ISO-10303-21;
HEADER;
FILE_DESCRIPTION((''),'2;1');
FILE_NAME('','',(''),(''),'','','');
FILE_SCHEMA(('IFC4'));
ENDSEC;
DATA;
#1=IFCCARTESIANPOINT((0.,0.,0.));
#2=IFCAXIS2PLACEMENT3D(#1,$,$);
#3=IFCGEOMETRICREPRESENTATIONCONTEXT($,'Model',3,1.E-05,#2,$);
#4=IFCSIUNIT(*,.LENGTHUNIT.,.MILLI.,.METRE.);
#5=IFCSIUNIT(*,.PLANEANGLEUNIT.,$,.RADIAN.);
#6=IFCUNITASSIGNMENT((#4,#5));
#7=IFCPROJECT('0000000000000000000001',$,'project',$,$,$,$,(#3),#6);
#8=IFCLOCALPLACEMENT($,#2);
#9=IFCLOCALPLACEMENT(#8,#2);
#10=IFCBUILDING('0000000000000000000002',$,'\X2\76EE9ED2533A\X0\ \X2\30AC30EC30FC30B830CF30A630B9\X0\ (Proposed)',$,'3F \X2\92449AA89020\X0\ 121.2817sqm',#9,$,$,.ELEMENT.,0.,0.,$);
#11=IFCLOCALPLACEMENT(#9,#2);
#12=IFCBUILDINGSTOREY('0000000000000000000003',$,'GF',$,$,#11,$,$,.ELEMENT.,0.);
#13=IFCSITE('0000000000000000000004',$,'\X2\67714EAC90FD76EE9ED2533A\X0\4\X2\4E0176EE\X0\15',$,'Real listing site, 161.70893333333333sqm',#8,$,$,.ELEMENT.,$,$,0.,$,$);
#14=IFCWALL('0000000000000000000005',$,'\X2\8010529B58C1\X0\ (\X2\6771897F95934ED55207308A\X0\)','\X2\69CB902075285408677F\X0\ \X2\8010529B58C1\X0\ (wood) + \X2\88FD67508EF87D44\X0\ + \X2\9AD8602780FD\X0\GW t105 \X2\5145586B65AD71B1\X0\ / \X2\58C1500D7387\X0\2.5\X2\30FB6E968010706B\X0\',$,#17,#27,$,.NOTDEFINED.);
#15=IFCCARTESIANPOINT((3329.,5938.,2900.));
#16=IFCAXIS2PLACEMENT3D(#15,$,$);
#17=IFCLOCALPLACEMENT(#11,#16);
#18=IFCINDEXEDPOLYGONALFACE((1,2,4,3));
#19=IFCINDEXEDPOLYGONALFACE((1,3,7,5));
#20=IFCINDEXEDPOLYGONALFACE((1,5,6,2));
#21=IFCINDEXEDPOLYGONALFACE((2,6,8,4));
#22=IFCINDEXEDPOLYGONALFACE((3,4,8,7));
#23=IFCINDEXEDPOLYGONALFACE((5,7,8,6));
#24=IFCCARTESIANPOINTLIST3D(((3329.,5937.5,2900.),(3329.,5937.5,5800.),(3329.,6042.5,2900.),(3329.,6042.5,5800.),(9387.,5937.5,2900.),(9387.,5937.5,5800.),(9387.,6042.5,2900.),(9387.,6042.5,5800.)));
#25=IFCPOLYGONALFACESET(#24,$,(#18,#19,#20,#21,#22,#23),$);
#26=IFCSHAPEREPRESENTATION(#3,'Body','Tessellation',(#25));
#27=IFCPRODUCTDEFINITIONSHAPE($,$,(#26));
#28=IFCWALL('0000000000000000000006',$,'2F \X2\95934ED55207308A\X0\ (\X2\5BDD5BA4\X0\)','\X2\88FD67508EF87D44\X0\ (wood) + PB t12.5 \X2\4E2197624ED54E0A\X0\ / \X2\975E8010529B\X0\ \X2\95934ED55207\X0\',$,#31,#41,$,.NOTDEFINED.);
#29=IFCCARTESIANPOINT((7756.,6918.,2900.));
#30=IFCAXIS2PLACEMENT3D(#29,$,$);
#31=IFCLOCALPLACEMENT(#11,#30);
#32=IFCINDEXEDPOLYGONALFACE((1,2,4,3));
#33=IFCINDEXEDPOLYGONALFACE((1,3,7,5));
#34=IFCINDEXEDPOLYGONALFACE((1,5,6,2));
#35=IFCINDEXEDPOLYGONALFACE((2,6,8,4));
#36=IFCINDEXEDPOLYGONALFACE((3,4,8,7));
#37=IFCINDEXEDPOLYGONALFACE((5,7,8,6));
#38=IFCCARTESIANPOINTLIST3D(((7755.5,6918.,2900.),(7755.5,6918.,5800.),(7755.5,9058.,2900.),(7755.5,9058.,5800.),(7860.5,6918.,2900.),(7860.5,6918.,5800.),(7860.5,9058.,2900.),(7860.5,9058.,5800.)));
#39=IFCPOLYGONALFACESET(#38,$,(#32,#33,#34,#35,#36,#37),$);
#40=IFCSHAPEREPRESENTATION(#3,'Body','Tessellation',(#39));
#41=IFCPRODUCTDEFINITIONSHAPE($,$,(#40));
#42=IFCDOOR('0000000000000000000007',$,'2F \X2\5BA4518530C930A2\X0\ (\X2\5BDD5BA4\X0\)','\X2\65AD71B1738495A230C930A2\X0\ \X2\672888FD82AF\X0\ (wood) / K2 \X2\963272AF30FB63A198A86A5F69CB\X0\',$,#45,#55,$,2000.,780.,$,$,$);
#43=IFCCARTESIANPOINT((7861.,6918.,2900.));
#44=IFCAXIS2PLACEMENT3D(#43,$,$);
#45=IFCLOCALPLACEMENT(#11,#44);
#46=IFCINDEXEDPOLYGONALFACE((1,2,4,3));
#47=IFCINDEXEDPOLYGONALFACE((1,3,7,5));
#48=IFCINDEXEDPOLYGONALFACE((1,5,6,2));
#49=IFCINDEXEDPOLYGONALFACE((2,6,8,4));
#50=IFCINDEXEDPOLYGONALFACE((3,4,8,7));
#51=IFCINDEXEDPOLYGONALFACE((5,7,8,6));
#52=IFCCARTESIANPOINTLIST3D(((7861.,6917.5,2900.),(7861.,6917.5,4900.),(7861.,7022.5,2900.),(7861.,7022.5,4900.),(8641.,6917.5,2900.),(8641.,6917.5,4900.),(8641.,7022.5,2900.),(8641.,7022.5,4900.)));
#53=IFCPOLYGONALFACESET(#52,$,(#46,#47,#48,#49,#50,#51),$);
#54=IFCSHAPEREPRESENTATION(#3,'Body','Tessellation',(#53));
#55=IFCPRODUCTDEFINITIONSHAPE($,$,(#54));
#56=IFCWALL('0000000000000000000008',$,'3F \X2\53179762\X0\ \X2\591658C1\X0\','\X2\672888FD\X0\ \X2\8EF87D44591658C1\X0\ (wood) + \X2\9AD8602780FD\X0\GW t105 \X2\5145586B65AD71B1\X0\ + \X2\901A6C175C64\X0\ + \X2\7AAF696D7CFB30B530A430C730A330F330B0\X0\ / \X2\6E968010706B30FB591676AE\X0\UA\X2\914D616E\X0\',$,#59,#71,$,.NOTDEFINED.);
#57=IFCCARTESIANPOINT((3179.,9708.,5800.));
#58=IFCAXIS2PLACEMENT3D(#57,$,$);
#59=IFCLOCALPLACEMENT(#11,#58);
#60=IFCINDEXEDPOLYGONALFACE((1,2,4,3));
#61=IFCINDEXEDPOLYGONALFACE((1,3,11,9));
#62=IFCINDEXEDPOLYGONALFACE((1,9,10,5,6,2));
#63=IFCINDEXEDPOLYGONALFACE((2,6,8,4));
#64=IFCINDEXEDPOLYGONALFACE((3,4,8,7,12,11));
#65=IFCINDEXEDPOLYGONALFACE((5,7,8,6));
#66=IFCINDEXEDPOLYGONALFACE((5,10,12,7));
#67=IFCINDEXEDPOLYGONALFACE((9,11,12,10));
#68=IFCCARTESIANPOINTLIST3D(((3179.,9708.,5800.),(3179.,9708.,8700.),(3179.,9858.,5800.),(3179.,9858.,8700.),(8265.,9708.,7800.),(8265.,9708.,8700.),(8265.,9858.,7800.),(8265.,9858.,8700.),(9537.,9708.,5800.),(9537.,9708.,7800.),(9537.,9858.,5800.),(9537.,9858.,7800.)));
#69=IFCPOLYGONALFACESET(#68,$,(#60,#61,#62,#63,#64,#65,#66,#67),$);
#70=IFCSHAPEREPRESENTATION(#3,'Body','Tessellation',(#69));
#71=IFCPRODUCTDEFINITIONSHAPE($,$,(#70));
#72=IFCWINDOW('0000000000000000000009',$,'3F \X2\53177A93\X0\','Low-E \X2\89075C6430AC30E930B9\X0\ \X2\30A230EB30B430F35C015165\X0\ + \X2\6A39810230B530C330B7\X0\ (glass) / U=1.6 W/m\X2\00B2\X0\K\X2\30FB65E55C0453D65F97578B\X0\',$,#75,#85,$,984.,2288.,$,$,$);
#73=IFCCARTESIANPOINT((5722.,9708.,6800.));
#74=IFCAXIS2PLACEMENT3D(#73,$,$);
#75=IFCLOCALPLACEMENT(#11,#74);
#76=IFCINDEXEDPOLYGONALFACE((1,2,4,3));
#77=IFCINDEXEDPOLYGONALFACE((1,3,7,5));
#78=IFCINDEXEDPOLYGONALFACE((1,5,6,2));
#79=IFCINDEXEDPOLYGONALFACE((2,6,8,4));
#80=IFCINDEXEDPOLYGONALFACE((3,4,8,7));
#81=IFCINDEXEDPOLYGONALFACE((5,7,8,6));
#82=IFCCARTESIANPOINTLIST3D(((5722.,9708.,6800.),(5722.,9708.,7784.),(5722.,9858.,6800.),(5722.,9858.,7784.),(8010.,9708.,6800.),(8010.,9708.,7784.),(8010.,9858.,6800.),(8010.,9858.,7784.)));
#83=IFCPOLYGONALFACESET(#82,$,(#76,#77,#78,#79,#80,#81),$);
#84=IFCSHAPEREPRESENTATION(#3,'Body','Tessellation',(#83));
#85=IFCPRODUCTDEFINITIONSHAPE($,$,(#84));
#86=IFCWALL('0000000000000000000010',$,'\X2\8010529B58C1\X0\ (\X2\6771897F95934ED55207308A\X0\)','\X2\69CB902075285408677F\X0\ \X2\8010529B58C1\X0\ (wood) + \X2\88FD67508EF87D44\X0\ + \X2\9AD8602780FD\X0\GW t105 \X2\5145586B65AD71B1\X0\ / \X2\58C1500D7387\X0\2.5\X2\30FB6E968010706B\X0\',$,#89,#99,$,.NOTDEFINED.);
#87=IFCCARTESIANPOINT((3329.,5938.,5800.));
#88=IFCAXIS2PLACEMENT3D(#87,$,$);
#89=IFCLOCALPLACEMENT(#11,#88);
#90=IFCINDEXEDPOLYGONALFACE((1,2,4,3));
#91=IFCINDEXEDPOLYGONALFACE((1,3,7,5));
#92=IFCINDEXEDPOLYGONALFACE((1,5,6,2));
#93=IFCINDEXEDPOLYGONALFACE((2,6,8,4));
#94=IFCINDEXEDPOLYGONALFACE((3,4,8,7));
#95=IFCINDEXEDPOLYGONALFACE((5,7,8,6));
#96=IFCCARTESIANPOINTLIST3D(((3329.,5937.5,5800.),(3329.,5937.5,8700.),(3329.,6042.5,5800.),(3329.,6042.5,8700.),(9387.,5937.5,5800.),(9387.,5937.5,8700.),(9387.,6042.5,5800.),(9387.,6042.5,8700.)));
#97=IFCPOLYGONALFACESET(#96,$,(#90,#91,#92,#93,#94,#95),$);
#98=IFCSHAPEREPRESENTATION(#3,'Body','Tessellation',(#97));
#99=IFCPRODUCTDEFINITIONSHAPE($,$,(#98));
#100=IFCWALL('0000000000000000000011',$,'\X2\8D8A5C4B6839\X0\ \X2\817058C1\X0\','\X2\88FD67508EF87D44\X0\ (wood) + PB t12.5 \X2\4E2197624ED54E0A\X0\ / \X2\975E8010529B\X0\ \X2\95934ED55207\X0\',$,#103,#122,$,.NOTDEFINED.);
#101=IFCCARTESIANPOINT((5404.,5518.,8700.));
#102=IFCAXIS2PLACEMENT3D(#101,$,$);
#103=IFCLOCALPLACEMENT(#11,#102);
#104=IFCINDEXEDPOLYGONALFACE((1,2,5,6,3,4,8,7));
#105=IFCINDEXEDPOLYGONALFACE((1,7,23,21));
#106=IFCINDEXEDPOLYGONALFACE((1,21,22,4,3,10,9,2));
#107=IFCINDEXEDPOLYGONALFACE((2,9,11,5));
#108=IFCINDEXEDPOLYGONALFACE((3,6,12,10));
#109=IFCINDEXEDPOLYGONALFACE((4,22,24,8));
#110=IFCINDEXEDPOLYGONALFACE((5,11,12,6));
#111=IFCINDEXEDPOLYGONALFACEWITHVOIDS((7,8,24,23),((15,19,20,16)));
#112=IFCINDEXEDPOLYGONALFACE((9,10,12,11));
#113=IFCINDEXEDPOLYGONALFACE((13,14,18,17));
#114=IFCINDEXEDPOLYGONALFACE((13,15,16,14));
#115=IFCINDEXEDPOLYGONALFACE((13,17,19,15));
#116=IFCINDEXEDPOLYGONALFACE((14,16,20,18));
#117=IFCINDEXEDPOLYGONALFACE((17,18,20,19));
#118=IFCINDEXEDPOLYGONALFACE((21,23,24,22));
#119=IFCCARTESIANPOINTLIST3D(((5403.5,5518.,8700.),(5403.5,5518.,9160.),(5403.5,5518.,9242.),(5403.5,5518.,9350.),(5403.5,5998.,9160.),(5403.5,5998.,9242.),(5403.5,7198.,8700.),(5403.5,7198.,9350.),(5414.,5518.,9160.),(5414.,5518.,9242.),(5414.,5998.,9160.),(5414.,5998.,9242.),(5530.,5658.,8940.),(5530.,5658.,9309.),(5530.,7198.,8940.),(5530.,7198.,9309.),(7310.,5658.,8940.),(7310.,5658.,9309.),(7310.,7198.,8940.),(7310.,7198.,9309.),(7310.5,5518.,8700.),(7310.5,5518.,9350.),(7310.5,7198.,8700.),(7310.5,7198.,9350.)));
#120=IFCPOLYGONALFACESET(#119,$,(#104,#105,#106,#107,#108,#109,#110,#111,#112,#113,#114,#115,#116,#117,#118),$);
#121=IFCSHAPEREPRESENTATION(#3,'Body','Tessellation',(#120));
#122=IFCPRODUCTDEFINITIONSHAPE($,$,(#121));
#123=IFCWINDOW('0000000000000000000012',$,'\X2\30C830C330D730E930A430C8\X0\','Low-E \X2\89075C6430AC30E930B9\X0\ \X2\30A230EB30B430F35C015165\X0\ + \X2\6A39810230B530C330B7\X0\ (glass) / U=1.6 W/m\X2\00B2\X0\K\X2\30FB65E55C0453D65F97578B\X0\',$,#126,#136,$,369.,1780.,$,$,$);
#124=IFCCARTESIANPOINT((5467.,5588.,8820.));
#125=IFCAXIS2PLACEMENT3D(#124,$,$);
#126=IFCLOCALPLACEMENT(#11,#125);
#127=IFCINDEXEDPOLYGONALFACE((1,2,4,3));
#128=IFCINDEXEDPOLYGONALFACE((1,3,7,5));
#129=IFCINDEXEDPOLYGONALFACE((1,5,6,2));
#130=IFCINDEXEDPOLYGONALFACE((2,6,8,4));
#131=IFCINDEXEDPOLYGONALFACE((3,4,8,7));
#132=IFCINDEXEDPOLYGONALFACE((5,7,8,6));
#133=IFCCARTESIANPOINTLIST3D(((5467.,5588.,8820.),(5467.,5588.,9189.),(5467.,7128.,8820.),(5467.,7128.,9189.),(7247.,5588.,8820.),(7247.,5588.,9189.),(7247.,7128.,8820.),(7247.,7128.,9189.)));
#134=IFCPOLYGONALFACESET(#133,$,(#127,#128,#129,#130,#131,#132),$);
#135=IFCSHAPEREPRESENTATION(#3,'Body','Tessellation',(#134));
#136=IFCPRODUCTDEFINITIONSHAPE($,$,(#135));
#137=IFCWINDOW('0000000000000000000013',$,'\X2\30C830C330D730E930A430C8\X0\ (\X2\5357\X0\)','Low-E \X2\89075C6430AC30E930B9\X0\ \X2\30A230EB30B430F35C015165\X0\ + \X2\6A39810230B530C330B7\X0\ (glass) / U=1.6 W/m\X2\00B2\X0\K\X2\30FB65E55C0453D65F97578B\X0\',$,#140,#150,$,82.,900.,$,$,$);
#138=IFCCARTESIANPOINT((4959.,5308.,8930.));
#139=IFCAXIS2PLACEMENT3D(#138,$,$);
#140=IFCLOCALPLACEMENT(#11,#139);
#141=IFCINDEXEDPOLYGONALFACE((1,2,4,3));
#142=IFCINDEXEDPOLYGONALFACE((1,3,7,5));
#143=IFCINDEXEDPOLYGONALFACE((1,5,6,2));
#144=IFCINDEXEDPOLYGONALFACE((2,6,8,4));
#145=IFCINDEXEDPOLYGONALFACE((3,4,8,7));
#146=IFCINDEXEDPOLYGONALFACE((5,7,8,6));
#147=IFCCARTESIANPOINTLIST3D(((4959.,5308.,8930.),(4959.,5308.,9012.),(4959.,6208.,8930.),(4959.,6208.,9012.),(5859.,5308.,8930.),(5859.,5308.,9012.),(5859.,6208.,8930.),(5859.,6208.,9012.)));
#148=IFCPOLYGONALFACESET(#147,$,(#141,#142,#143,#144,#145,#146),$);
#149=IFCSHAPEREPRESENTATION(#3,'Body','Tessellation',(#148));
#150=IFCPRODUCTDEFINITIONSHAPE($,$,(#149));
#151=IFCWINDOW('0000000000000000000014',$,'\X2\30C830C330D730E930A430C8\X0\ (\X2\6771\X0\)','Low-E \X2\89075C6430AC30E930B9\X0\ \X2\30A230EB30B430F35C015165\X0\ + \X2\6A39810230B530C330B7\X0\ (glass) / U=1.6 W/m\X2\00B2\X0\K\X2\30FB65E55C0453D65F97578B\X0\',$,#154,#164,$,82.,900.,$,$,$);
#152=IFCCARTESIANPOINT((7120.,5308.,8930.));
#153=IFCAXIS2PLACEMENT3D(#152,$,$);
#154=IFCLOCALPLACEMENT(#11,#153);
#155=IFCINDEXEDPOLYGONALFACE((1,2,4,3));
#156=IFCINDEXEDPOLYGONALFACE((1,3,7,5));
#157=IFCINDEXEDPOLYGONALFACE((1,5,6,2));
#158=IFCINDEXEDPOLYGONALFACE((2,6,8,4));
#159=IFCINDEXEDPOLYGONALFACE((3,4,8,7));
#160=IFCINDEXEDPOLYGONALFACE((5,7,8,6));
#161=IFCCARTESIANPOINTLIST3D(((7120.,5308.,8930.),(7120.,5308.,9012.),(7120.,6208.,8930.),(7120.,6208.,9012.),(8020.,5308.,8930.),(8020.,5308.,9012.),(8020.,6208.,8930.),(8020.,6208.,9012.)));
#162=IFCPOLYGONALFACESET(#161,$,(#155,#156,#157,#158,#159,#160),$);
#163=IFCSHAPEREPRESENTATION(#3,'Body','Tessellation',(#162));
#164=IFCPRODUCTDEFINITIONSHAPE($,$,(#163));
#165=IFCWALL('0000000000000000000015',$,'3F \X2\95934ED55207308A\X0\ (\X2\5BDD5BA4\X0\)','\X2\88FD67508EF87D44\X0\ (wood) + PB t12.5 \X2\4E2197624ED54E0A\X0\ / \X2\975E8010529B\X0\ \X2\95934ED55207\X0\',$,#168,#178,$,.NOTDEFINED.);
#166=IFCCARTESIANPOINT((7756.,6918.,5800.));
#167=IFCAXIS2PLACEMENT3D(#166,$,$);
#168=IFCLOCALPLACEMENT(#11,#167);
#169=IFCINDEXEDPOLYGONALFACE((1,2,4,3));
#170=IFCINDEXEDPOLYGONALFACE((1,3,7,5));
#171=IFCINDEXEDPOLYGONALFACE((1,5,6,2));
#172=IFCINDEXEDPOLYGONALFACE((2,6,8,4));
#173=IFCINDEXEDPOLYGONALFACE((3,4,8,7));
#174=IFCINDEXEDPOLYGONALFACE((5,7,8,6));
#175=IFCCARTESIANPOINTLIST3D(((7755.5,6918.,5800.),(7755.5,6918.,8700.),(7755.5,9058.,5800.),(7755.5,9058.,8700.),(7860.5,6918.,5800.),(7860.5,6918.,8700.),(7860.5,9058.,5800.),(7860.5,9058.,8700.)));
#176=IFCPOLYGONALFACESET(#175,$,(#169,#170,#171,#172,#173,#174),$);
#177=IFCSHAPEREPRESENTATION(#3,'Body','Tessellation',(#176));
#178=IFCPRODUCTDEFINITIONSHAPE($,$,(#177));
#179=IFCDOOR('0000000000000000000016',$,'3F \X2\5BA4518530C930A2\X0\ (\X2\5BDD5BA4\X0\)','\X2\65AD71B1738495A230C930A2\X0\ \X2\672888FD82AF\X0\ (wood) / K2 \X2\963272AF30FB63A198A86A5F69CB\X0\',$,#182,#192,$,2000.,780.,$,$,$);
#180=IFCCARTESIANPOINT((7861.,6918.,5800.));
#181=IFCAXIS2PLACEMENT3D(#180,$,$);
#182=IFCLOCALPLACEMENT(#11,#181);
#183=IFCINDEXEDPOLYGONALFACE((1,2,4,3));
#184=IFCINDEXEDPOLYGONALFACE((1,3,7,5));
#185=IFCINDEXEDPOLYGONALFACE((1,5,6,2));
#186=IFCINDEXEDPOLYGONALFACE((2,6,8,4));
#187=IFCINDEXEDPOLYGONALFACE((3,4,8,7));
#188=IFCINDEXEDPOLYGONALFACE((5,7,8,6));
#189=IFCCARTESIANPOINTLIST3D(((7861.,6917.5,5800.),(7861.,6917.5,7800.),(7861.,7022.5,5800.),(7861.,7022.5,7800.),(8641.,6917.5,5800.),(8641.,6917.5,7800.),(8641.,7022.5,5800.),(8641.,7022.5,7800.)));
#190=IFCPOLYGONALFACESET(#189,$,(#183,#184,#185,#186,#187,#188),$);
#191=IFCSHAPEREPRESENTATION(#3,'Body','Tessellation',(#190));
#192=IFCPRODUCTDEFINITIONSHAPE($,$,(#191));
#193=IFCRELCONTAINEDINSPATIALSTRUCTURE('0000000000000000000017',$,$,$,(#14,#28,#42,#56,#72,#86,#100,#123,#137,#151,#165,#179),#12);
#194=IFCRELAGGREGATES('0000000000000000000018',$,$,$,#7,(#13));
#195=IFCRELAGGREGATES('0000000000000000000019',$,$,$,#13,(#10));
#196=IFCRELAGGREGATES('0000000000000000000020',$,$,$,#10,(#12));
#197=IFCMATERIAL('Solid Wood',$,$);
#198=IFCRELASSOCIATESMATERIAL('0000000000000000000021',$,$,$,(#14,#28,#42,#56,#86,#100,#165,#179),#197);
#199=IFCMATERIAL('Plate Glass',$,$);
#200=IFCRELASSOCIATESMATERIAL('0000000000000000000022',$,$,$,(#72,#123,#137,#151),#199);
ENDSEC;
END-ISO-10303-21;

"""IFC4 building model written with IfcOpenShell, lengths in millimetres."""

from ifc_helpers import new_model, si_unit, frame, frame_2d, origin, place, context, project, spatial, rectangle, extrude, material, element, fill, save


model = new_model("IFC4")

# Units and contexts
model_context = context("Model", 3, precision=1e-05, world=origin())
ifc_project = project(units=[si_unit("LENGTHUNIT", "METRE", prefix="MILLI"), si_unit("PLANEANGLEUNIT", "RADIAN")], contexts=[model_context])

# Site, building, storey
site_placement = place(None, origin())
site = spatial("IfcSite", under=ifc_project, at=site_placement, Name="東京都目黒区4丁目15", ObjectType="Real listing site, 161.70893333333333sqm", CompositionType="ELEMENT", RefElevation=0.0)
building_placement = place(site_placement, origin())
building = spatial("IfcBuilding", under=site, at=building_placement, Name="目黒区 ガレージハウス (Proposed)", ObjectType="3F 鉄骨造 121.2817sqm", CompositionType="ELEMENT", ElevationOfRefHeight=0.0, ElevationOfTerrain=0.0)
storey_placement = place(building_placement, origin())
storey = spatial("IfcBuildingStorey", under=building, at=storey_placement, Name="GF", CompositionType="ELEMENT", Elevation=0.0)

# Walls
ifc_material_1 = material(Name="Solid Wood")
wall_1_placement = place(storey_placement, frame((3329.0, 5938.0, 2900.0)))
element("IfcWall", 1, at=wall_1_placement, inside=storey, material=ifc_material_1, Name="耐力壁 (東西間仕切り)", Description="構造用合板 耐力壁 (wood) + 製材軸組 + 高性能GW t105 充填断熱 / 壁倍率2.5・準耐火", PredefinedType="NOTDEFINED", context=model_context, shape_type="SweptSolid", body=[
    extrude(rectangle(XDim=6058.0, YDim=105.0, at=frame_2d((3029.0, 52.0))), frame((3329.0, 5938.0, 2900.0)), (0.0, 0.0, 1.0), 2900.0),
])
wall_2_placement = place(storey_placement, frame((7756.0, 6918.0, 2900.0)))
element("IfcWall", 2, at=wall_2_placement, inside=storey, material=ifc_material_1, Name="2F 間仕切り (寝室)", Description="製材軸組 (wood) + PB t12.5 両面仕上 / 非耐力 間仕切", PredefinedType="NOTDEFINED", context=model_context, shape_type="SweptSolid", body=[
    extrude(rectangle(XDim=105.0, YDim=2140.0, at=frame_2d((52.0, 1070.0))), frame((7756.0, 6918.0, 2900.0)), (0.0, 0.0, 1.0), 2900.0),
])

# Door
door_1_placement = place(storey_placement, frame((7861.0, 6918.0, 2900.0)))
element("IfcDoor", 3, at=door_1_placement, inside=storey, material=ifc_material_1, Name="2F 室内ドア (寝室)", Description="断熱玄関ドア 木製芯 (wood) / K2 防犯・採風機構", OverallHeight=2000.0, OverallWidth=780.0, context=model_context, shape_type="SweptSolid", body=[
    extrude(rectangle(XDim=780.0, YDim=105.0, at=frame_2d((390.0, 52.0))), frame((7861.0, 6918.0, 2900.0)), (0.0, 0.0, 1.0), 2000.0),
])

# Wall, opening, window
wall_3_placement = place(storey_placement, frame((3179.0, 9708.0, 5800.0)))
wall_3 = element("IfcWall", 4, at=wall_3_placement, inside=storey, material=ifc_material_1, Name="3F 北面 外壁", Description="木製 軸組外壁 (wood) + 高性能GW t105 充填断熱 + 通気層 + 窯業系サイディング / 準耐火・外皮UA配慮", PredefinedType="NOTDEFINED", context=model_context, shape_type="SweptSolid", body=[
    extrude(rectangle(XDim=6358.0, YDim=150.0, at=frame_2d((3179.0, 75.0))), frame((3179.0, 9708.0, 5800.0)), (0.0, 0.0, 1.0), 2900.0),
])
opening_1_placement = place(storey_placement, frame((5722.0, 9708.0, 6800.0)))
opening_1 = element("IfcOpeningElement", 5, at=opening_1_placement, cuts=wall_3, PredefinedType="NOTDEFINED", context=model_context, shape_type="SweptSolid", body=[
    extrude(rectangle(XDim=2288.0, YDim=150.0, at=frame_2d((1144.0, 75.0))), frame((5722.0, 9708.0, 6800.0)), (0.0, 0.0, 1.0), 984.0),
])
ifc_material_2 = material(Name="Plate Glass")
window_1_placement = place(storey_placement, frame((5722.0, 9708.0, 6800.0)))
window_1 = element("IfcWindow", 6, at=window_1_placement, inside=storey, material=ifc_material_2, Name="3F 北窓", Description="Low-E 複層ガラス アルゴン封入 + 樹脂サッシ (glass) / U=1.6 W/m²K・日射取得型", OverallHeight=984.0, OverallWidth=2288.0, context=model_context, shape_type="SweptSolid", body=[
    extrude(rectangle(XDim=2288.0, YDim=150.0, at=frame_2d((1144.0, 75.0))), frame((5722.0, 9708.0, 6800.0)), (0.0, 0.0, 1.0), 984.0),
])
fill(opening_1, window_1)

# Wall
wall_4_placement = place(storey_placement, frame((3329.0, 5938.0, 5800.0)))
element("IfcWall", 7, at=wall_4_placement, inside=storey, material=ifc_material_1, Name="耐力壁 (東西間仕切り)", Description="構造用合板 耐力壁 (wood) + 製材軸組 + 高性能GW t105 充填断熱 / 壁倍率2.5・準耐火", PredefinedType="NOTDEFINED", context=model_context, shape_type="SweptSolid", body=[
    extrude(rectangle(XDim=6058.0, YDim=105.0, at=frame_2d((3029.0, 52.0))), frame((3329.0, 5938.0, 5800.0)), (0.0, 0.0, 1.0), 2900.0),
])

# Wall, openings, windows
wall_5_placement = place(storey_placement, frame((5404.0, 5518.0, 8700.0)))
wall_5 = element("IfcWall", 8, at=wall_5_placement, inside=storey, material=ifc_material_1, Name="越屋根 腰壁", Description="製材軸組 (wood) + PB t12.5 両面仕上 / 非耐力 間仕切", PredefinedType="NOTDEFINED", context=model_context, shape_type="SweptSolid", body=[
    extrude(rectangle(XDim=1907.0, YDim=1680.0, at=frame_2d((953.0, 840.0))), frame((5404.0, 5518.0, 8700.0)), (0.0, 0.0, 1.0), 650.0),
])
opening_2_placement = place(storey_placement, frame((5467.0, 5588.0, 8820.0)))
opening_2 = element("IfcOpeningElement", 9, at=opening_2_placement, cuts=wall_5, PredefinedType="NOTDEFINED", context=model_context, shape_type="SweptSolid", body=[
    extrude(rectangle(XDim=1780.0, YDim=1540.0, at=frame_2d((890.0, 770.0))), frame((5467.0, 5588.0, 8820.0)), (0.0, 0.0, 1.0), 369.0),
])
opening_3_placement = place(storey_placement, frame((4959.0, 5308.0, 8930.0)))
opening_3 = element("IfcOpeningElement", 10, at=opening_3_placement, cuts=wall_5, PredefinedType="NOTDEFINED", context=model_context, shape_type="SweptSolid", body=[
    extrude(rectangle(XDim=900.0, YDim=900.0, at=frame_2d((450.0, 450.0))), frame((4959.0, 5308.0, 8930.0)), (0.0, 0.0, 1.0), 82.0),
])
opening_4_placement = place(storey_placement, frame((7120.0, 5308.0, 8930.0)))
opening_4 = element("IfcOpeningElement", 11, at=opening_4_placement, cuts=wall_5, PredefinedType="NOTDEFINED", context=model_context, shape_type="SweptSolid", body=[
    extrude(rectangle(XDim=900.0, YDim=900.0, at=frame_2d((450.0, 450.0))), frame((7120.0, 5308.0, 8930.0)), (0.0, 0.0, 1.0), 82.0),
])
window_2_placement = place(storey_placement, frame((5467.0, 5588.0, 8820.0)))
window_2 = element("IfcWindow", 12, at=window_2_placement, inside=storey, material=ifc_material_2, Name="トップライト", Description="Low-E 複層ガラス アルゴン封入 + 樹脂サッシ (glass) / U=1.6 W/m²K・日射取得型", OverallHeight=369.0, OverallWidth=1780.0, context=model_context, shape_type="SweptSolid", body=[
    extrude(rectangle(XDim=1780.0, YDim=1540.0, at=frame_2d((890.0, 770.0))), frame((5467.0, 5588.0, 8820.0)), (0.0, 0.0, 1.0), 369.0),
])
fill(opening_2, window_2)
window_3_placement = place(storey_placement, frame((4959.0, 5308.0, 8930.0)))
window_3 = element("IfcWindow", 13, at=window_3_placement, inside=storey, material=ifc_material_2, Name="トップライト (南)", Description="Low-E 複層ガラス アルゴン封入 + 樹脂サッシ (glass) / U=1.6 W/m²K・日射取得型", OverallHeight=82.0, OverallWidth=900.0, context=model_context, shape_type="SweptSolid", body=[
    extrude(rectangle(XDim=900.0, YDim=900.0, at=frame_2d((450.0, 450.0))), frame((4959.0, 5308.0, 8930.0)), (0.0, 0.0, 1.0), 82.0),
])
fill(opening_3, window_3)
window_4_placement = place(storey_placement, frame((7120.0, 5308.0, 8930.0)))
window_4 = element("IfcWindow", 14, at=window_4_placement, inside=storey, material=ifc_material_2, Name="トップライト (東)", Description="Low-E 複層ガラス アルゴン封入 + 樹脂サッシ (glass) / U=1.6 W/m²K・日射取得型", OverallHeight=82.0, OverallWidth=900.0, context=model_context, shape_type="SweptSolid", body=[
    extrude(rectangle(XDim=900.0, YDim=900.0, at=frame_2d((450.0, 450.0))), frame((7120.0, 5308.0, 8930.0)), (0.0, 0.0, 1.0), 82.0),
])
fill(opening_4, window_4)

# Wall
wall_6_placement = place(storey_placement, frame((7756.0, 6918.0, 5800.0)))
element("IfcWall", 15, at=wall_6_placement, inside=storey, material=ifc_material_1, Name="3F 間仕切り (寝室)", Description="製材軸組 (wood) + PB t12.5 両面仕上 / 非耐力 間仕切", PredefinedType="NOTDEFINED", context=model_context, shape_type="SweptSolid", body=[
    extrude(rectangle(XDim=105.0, YDim=2140.0, at=frame_2d((52.0, 1070.0))), frame((7756.0, 6918.0, 5800.0)), (0.0, 0.0, 1.0), 2900.0),
])

# Door
door_2_placement = place(storey_placement, frame((7861.0, 6918.0, 5800.0)))
element("IfcDoor", 16, at=door_2_placement, inside=storey, material=ifc_material_1, Name="3F 室内ドア (寝室)", Description="断熱玄関ドア 木製芯 (wood) / K2 防犯・採風機構", OverallHeight=2000.0, OverallWidth=780.0, context=model_context, shape_type="SweptSolid", body=[
    extrude(rectangle(XDim=780.0, YDim=105.0, at=frame_2d((390.0, 52.0))), frame((7861.0, 6918.0, 5800.0)), (0.0, 0.0, 1.0), 2000.0),
])

save(model, "model.ifc")
